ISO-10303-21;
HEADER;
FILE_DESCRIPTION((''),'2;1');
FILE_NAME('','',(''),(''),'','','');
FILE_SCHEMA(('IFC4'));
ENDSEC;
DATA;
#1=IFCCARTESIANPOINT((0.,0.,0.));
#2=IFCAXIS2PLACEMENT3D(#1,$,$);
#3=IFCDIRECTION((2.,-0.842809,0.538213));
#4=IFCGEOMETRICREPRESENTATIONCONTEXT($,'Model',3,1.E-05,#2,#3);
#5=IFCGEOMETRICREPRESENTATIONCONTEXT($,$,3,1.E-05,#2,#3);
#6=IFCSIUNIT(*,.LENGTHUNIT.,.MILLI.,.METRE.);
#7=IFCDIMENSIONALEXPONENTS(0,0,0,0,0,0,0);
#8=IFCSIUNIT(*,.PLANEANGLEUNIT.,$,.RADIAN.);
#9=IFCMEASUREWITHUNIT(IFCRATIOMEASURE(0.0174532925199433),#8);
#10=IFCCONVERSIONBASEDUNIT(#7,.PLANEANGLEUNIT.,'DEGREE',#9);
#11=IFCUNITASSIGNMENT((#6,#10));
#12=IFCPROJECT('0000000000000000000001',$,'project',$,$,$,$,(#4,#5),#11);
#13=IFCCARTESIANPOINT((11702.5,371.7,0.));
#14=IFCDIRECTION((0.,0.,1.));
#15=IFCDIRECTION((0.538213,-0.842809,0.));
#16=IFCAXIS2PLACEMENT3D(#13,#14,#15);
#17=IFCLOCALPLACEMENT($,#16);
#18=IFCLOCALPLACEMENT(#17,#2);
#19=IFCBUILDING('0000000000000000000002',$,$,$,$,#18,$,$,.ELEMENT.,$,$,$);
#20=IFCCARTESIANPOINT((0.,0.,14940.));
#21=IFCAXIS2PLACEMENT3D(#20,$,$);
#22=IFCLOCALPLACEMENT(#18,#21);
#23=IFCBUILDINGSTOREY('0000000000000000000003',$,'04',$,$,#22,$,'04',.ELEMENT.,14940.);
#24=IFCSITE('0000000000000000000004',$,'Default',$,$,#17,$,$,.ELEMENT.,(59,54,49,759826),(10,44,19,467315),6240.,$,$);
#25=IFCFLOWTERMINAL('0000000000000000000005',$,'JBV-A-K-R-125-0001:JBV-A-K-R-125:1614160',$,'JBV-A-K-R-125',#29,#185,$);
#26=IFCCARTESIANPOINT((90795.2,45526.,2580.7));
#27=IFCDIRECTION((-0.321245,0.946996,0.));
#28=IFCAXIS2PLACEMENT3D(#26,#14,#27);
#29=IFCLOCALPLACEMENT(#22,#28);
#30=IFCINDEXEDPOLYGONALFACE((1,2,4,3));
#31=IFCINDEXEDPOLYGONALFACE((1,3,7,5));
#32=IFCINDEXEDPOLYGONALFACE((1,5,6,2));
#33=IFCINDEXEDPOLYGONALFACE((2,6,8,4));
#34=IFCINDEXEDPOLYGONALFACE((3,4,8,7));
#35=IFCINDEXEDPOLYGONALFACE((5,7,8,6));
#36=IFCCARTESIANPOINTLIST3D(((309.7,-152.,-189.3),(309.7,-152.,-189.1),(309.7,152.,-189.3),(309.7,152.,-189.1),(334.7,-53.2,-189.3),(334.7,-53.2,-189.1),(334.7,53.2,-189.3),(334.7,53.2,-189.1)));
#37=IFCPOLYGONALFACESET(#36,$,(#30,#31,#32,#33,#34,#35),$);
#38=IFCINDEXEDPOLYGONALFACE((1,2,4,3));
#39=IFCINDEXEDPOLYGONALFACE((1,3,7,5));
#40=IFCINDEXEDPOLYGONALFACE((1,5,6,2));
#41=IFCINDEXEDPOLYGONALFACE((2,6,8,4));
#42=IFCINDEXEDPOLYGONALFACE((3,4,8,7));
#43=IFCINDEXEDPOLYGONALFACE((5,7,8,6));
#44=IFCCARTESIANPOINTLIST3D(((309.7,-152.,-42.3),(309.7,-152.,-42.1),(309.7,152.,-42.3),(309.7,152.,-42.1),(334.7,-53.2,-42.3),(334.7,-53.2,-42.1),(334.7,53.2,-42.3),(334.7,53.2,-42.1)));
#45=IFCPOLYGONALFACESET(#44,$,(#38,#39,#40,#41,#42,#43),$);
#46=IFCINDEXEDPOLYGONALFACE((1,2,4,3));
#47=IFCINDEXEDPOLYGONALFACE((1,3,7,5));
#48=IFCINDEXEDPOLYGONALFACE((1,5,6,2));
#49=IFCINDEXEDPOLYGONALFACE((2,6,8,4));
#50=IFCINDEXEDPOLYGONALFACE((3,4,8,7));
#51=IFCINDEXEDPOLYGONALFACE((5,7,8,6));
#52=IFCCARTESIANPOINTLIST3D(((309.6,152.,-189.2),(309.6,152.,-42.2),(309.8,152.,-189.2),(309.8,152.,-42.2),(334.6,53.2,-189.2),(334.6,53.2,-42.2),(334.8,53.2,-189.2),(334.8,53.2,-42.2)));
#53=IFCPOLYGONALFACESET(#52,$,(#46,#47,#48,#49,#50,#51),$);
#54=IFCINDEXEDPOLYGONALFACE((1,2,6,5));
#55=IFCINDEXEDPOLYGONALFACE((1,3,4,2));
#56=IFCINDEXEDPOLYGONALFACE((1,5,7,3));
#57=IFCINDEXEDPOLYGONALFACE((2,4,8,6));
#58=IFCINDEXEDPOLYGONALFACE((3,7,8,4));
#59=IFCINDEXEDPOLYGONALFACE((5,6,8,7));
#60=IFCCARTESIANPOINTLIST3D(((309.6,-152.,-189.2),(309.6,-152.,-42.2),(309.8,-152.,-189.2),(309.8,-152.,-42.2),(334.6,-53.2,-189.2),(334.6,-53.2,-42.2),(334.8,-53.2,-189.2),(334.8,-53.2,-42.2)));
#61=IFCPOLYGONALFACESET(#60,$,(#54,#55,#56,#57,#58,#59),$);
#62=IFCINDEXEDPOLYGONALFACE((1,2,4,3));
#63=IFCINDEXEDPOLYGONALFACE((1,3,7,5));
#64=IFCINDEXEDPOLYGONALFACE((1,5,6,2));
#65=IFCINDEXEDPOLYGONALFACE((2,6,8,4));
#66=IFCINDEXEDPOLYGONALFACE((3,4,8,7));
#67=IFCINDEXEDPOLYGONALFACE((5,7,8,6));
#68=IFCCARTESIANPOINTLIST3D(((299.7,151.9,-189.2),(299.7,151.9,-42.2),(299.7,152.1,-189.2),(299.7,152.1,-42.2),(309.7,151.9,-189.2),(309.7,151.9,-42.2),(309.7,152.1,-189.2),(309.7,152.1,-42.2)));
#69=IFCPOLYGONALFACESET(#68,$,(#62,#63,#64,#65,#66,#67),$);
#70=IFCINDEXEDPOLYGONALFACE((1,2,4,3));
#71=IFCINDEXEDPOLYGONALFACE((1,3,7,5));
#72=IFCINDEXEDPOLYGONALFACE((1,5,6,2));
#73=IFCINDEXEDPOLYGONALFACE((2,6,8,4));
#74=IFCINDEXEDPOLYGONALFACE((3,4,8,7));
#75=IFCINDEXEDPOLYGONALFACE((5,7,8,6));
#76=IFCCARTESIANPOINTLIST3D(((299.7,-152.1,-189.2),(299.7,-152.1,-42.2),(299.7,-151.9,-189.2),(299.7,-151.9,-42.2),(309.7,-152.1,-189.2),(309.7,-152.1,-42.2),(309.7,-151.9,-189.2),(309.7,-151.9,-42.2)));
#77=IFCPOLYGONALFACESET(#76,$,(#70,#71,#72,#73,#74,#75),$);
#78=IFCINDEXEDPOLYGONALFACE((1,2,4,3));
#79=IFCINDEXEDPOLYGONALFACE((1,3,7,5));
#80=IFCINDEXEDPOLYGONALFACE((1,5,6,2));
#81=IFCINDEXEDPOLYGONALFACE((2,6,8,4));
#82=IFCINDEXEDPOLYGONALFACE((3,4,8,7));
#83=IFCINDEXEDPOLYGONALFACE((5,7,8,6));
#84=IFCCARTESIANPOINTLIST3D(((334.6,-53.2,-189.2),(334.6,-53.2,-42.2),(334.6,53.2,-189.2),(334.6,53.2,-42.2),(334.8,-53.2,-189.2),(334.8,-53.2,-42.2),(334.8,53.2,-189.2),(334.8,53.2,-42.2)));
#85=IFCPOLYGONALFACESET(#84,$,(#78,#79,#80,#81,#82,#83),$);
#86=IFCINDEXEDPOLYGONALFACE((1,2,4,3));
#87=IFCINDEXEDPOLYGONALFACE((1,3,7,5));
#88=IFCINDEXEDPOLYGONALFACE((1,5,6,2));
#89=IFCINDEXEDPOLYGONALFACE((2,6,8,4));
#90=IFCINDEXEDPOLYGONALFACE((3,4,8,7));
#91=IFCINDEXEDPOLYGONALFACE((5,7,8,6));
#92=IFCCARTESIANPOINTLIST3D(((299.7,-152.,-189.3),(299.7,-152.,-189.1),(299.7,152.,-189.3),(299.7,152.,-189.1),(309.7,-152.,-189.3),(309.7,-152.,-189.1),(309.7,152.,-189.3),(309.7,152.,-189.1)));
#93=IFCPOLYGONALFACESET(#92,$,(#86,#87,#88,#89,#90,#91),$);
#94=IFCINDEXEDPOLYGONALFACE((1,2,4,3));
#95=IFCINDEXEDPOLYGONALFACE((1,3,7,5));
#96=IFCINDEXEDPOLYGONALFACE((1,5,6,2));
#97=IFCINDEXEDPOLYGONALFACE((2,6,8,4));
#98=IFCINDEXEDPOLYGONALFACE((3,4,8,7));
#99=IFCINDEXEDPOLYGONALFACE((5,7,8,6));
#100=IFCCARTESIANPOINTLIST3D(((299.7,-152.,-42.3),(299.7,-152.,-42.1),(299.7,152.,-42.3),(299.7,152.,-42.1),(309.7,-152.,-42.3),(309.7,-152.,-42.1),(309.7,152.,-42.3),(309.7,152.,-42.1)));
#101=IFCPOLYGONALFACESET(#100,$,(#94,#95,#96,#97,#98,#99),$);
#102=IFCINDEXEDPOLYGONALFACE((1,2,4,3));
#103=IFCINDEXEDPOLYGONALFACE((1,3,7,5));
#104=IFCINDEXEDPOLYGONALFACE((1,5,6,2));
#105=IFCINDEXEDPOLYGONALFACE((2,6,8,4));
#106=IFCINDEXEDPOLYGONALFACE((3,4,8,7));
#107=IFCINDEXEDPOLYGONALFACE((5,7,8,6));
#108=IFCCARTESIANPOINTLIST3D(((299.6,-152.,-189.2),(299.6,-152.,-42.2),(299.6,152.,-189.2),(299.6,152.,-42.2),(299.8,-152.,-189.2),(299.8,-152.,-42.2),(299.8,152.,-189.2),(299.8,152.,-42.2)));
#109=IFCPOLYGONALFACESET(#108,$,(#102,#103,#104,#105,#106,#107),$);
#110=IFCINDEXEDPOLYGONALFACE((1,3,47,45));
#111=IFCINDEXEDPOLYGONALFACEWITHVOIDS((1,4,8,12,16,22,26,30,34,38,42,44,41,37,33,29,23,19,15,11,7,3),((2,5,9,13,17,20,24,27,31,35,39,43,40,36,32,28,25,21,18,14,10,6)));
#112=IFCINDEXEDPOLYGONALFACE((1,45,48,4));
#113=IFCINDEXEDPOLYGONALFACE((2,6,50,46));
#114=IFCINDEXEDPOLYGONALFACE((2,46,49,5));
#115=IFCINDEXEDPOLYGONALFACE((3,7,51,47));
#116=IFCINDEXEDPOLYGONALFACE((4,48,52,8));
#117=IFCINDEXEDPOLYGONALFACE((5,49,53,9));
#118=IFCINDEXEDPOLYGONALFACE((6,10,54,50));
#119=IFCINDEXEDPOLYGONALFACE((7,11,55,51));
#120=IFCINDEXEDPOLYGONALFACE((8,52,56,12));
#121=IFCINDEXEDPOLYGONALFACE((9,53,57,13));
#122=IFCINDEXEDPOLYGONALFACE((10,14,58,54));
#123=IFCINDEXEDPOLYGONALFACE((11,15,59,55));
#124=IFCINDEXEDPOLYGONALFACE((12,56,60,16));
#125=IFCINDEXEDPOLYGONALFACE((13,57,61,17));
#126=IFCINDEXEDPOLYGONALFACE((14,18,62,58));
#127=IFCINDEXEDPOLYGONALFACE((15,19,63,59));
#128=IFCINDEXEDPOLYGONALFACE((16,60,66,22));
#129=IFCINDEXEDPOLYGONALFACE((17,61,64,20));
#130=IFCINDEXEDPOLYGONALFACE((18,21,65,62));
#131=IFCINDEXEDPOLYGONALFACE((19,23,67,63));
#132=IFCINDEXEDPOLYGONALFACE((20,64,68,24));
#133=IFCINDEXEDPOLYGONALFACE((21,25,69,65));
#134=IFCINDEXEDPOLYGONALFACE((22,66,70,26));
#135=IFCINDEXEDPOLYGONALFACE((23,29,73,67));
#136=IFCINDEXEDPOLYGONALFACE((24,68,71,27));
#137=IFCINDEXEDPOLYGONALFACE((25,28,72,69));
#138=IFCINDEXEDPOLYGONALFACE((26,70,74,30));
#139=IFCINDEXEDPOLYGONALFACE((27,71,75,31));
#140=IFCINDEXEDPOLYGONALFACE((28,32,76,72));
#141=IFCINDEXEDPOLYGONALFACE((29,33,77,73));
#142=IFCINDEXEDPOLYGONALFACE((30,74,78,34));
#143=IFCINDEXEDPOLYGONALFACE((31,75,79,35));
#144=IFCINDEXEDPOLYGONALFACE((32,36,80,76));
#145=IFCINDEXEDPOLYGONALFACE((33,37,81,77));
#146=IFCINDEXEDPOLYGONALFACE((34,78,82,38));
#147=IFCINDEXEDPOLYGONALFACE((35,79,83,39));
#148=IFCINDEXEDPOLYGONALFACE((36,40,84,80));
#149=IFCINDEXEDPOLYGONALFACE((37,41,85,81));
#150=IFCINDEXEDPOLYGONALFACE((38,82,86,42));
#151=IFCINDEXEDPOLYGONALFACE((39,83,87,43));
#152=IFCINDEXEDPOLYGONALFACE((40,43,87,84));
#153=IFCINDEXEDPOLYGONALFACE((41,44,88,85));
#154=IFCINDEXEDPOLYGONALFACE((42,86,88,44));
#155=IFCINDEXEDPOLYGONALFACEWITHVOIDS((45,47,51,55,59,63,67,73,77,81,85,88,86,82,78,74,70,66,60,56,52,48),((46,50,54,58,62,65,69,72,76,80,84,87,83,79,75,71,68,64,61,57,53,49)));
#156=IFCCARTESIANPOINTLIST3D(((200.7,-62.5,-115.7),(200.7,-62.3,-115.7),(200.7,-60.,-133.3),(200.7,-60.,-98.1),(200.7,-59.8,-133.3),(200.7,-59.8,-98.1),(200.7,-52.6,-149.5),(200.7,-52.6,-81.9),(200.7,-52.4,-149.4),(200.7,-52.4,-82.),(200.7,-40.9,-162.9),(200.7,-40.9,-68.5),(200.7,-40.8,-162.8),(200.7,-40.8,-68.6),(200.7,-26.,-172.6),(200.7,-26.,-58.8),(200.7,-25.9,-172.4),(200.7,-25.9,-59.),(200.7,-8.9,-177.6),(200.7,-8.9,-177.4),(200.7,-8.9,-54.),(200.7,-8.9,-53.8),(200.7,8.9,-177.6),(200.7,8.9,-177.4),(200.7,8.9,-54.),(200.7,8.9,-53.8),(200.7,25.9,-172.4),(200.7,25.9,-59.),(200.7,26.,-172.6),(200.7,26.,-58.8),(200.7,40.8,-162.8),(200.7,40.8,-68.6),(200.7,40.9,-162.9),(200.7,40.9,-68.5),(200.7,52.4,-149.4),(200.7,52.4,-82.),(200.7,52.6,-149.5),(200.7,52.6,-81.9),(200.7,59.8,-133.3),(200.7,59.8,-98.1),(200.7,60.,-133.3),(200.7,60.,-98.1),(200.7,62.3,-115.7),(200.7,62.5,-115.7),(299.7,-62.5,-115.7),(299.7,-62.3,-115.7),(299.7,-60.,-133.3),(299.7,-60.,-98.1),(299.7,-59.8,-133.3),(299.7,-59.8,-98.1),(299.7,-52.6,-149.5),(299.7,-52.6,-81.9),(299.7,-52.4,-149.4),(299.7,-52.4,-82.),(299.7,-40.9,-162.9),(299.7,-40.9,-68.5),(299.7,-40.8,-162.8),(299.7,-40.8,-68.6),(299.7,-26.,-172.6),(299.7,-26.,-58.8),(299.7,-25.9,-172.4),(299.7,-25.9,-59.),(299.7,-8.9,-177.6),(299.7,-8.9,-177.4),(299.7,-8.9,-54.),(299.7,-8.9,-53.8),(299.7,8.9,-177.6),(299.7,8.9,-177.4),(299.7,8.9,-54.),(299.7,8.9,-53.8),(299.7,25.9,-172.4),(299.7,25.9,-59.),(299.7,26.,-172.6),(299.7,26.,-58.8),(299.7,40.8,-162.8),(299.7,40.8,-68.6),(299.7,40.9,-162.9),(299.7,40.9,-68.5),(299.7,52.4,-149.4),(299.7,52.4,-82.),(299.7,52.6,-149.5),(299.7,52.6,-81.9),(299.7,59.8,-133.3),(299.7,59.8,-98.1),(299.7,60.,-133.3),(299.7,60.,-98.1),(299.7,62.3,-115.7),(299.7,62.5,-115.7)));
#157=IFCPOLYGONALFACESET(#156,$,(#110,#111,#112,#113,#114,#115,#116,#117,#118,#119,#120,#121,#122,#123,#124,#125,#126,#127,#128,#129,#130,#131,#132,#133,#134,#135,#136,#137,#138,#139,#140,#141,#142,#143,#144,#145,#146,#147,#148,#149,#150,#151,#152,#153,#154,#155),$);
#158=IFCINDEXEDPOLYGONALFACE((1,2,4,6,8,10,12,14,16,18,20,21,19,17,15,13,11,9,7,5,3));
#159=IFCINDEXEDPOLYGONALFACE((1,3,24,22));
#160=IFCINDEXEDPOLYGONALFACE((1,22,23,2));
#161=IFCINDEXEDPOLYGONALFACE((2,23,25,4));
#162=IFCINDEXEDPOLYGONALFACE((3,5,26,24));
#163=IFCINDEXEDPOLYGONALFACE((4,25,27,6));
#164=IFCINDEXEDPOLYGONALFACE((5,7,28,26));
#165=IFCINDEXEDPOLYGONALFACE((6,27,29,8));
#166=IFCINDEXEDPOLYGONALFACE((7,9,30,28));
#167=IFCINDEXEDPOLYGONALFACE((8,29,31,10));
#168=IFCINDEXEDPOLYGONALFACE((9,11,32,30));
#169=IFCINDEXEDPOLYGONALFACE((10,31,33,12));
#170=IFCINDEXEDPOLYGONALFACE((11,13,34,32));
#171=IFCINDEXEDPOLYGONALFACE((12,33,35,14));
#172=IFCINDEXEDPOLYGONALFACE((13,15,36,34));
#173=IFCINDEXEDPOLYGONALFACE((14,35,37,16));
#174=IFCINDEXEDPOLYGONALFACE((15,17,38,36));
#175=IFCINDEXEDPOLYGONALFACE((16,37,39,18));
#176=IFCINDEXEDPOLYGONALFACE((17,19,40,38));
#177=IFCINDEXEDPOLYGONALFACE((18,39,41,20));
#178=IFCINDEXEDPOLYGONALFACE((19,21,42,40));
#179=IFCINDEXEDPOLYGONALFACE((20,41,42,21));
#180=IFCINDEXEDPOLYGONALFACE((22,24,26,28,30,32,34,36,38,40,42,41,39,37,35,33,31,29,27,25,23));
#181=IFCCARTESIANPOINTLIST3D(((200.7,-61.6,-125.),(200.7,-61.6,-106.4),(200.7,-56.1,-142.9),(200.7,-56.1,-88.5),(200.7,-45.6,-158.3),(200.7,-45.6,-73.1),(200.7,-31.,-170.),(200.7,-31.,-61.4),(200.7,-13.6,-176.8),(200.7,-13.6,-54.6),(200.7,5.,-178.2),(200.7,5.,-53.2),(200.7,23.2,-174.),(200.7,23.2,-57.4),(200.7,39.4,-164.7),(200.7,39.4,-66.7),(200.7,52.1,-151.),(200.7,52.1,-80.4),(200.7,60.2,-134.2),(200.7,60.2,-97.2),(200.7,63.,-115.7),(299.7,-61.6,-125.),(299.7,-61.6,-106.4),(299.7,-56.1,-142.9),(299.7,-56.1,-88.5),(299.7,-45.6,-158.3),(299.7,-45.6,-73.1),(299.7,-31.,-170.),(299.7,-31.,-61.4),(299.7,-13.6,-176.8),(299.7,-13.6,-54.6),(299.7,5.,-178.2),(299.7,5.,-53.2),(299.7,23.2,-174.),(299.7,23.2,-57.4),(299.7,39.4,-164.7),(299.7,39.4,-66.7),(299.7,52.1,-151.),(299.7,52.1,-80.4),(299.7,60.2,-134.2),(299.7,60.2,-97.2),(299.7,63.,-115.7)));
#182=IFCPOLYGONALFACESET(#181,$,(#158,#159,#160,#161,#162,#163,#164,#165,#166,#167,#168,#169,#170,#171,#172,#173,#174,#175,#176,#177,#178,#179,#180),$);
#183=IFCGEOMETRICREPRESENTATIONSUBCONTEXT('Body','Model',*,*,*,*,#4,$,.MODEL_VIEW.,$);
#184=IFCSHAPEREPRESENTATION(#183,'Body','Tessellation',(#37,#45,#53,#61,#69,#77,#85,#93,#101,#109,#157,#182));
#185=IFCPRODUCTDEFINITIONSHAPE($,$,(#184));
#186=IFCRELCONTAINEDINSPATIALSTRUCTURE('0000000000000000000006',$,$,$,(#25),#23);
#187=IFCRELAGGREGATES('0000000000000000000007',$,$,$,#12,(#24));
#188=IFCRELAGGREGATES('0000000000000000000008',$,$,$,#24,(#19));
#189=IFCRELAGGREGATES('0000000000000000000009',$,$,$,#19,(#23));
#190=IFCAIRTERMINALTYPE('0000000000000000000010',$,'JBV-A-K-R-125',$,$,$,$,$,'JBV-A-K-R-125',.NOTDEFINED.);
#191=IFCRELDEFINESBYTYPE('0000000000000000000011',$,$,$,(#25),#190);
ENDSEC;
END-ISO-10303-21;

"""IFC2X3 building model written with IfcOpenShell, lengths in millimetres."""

from ifc_helpers import new_model, entity, si_unit, converted_unit, direction, frame, frame_2d, origin, origin_2d_with_axis, place, context, subcontext, project, spatial, polyline, circle_curve, parameter, trimmed, segment, composite_curve, rectangle, circle, outline, extrude, source, transform, mapped, type_object, type_shapes, element, save


model = new_model("IFC2X3")

# Units and contexts
model_context = context("Model", 3, precision=1e-05, world=origin(), true_north=direction((2.0, -0.842809, 0.538213)))
context_of_model = context(None, 3, precision=1e-05, world=origin(), true_north=direction((2.0, -0.842809, 0.538213)))
body_context = subcontext(model_context, "Body", "Model", "MODEL_VIEW")
ifc_project = project(units=[si_unit("LENGTHUNIT", "METRE", prefix="MILLI"), converted_unit("PLANEANGLEUNIT", "DEGREE", entity("IfcRatioMeasure", 0.0174532925199433), si_unit("PLANEANGLEUNIT", "RADIAN"), dimensions=[0, 0, 0, 0, 0, 0, 0])], contexts=[model_context, context_of_model])

# Site, building, storey
site_placement = place(None, frame((11702.5, 371.7, 0.0), z_axis=(0.0, 0.0, 1.0), x_axis=(0.538213, -0.842809, 0.0)))
site = spatial("IfcSite", under=ifc_project, at=site_placement, Name="Default", CompositionType="ELEMENT", RefLatitude=(59, 54, 49, 759826), RefLongitude=(10, 44, 19, 467315), RefElevation=6240.0)
building_placement = place(site_placement, origin())
building = spatial("IfcBuilding", under=site, at=building_placement, CompositionType="ELEMENT")
storey_placement = place(building_placement, frame((0.0, 0.0, 14940.0)))
storey = spatial("IfcBuildingStorey", under=building, at=storey_placement, Name="04", LongName="04", CompositionType="ELEMENT", Elevation=14940.0)

# Flow terminal
air_terminal_type_1 = type_object("IfcAirTerminalType", Name="JBV-A-K-R-125", ElementType="JBV-A-K-R-125", PredefinedType="NOTDEFINED")
shared_shape_1 = source(origin(), body_context, "Body", "SweptSolid", [
    extrude(outline(polyline([(-152.0, -12.5), (152.0, -12.5), (53.2, 12.5), (-53.2, 12.5), (-152.0, -12.5)])), frame((322.2, 0.0, -189.3), z_axis=(0.0, 0.0, 1.0), x_axis=(0.0, -1.0, 0.0)), (0.0, 0.0, 1.0), 0.2),
    extrude(outline(polyline([(-152.0, -12.5), (152.0, -12.5), (53.2, 12.5), (-53.2, 12.5), (-152.0, -12.5)])), frame((322.2, 0.0, -42.3), z_axis=(0.0, 0.0, 1.0), x_axis=(0.0, -1.0, 0.0)), (0.0, 0.0, 1.0), 0.2),
    extrude(rectangle(XDim=0.2, YDim=101.9, at=frame_2d((0.0, 0.0), x_axis=(1.0, 0.0))), frame((322.2, 102.6, -189.2), z_axis=(0.0, 0.0, 1.0), x_axis=(0.969446, 0.245305, 0.0)), (0.0, 0.0, 1.0), 147.0),
    extrude(rectangle(XDim=0.2, YDim=101.9, at=frame_2d((0.0, 0.0), x_axis=(1.0, 0.0))), frame((322.2, -102.6, -189.2), z_axis=(0.0, 0.0, 1.0), x_axis=(-0.969446, 0.245305, 0.0)), (0.0, 0.0, 1.0), 147.0),
    extrude(rectangle(XDim=0.2, YDim=10.0, at=frame_2d((0.0, 0.0), x_axis=(1.0, 0.0))), frame((304.7, 152.0, -189.2), z_axis=(0.0, 0.0, 1.0), x_axis=(0.0, 1.0, 0.0)), (0.0, 0.0, 1.0), 147.0),
    extrude(rectangle(XDim=0.2, YDim=10.0, at=frame_2d((0.0, 0.0), x_axis=(1.0, 0.0))), frame((304.7, -152.0, -189.2), z_axis=(0.0, 0.0, 1.0), x_axis=(0.0, 1.0, 0.0)), (0.0, 0.0, 1.0), 147.0),
    extrude(rectangle(XDim=0.2, YDim=106.4, at=frame_2d((0.0, 0.0), x_axis=(1.0, 0.0))), frame((334.7, 0.0, -189.2)), (0.0, 0.0, 1.0), 147.0),
    extrude(rectangle(XDim=304.0, YDim=10.0, at=frame_2d((0.0, 0.0), x_axis=(1.0, 0.0))), frame((304.7, 0.0, -189.3), z_axis=(0.0, 0.0, 1.0), x_axis=(0.0, -1.0, 0.0)), (0.0, 0.0, 1.0), 0.2),
    extrude(rectangle(XDim=304.0, YDim=10.0, at=frame_2d((0.0, 0.0), x_axis=(1.0, 0.0))), frame((304.7, 0.0, -42.3), z_axis=(0.0, 0.0, 1.0), x_axis=(0.0, -1.0, 0.0)), (0.0, 0.0, 1.0), 0.2),
    extrude(rectangle(XDim=0.2, YDim=304.0, at=frame_2d((0.0, 0.0), x_axis=(1.0, 0.0))), frame((299.7, 0.0, -189.2)), (0.0, 0.0, 1.0), 147.0),
    extrude(outline(composite_curve([segment(trimmed(circle_curve(origin_2d_with_axis(), 62.5), [parameter(0.0)], [parameter(180.0)], True, "PARAMETER"), True, "CONTINUOUS"), segment(trimmed(circle_curve(origin_2d_with_axis(), 62.5), [parameter(180.0)], [parameter(360.0)], True, "PARAMETER"), True, "CONTINUOUS")], self_intersect=False), holes=[composite_curve([segment(trimmed(circle_curve(origin_2d_with_axis(), 62.3), [parameter(180.0)], [parameter(360.0)], True, "PARAMETER"), False, "CONTINUOUS"), segment(trimmed(circle_curve(origin_2d_with_axis(), 62.3), [parameter(0.0)], [parameter(180.0)], True, "PARAMETER"), False, "CONTINUOUS")], self_intersect=False)]), frame((200.7, 0.0, -115.7), z_axis=(1.0, 0.0, 0.0), x_axis=(0.0, 1.0, 0.0)), (0.0, 0.0, 1.0), 99.0),
    extrude(circle(Radius=62.6, at=frame_2d((0.0, 0.0), x_axis=(1.0, 0.0))), frame((200.7, 0.3, -115.7), z_axis=(1.0, 0.0, 0.0), x_axis=(0.0, 1.0, 0.0)), (0.0, 0.0, 1.0), 99.0),
])
type_shapes(air_terminal_type_1, [shared_shape_1])
for number, where, z_axis, x_axis, name in (
    (1, (90795.2, 45526.0, 2580.7), (0.0, 0.0, 1.0), (-0.321245, 0.946996, 0.0), "JBV-A-K-R-125-0001:JBV-A-K-R-125:1614160"),
):
    element("IfcFlowTerminal", number, at=place(storey_placement, frame(where, z_axis=z_axis, x_axis=x_axis)), inside=storey, type_object=air_terminal_type_1, Name=name, ObjectType="JBV-A-K-R-125", context=body_context, shape_type="MappedRepresentation", body=[
        mapped(shared_shape_1, transform((0.0, 0.0, 0.0), scale=1.0)),
    ])

save(model, "model.ifc")
